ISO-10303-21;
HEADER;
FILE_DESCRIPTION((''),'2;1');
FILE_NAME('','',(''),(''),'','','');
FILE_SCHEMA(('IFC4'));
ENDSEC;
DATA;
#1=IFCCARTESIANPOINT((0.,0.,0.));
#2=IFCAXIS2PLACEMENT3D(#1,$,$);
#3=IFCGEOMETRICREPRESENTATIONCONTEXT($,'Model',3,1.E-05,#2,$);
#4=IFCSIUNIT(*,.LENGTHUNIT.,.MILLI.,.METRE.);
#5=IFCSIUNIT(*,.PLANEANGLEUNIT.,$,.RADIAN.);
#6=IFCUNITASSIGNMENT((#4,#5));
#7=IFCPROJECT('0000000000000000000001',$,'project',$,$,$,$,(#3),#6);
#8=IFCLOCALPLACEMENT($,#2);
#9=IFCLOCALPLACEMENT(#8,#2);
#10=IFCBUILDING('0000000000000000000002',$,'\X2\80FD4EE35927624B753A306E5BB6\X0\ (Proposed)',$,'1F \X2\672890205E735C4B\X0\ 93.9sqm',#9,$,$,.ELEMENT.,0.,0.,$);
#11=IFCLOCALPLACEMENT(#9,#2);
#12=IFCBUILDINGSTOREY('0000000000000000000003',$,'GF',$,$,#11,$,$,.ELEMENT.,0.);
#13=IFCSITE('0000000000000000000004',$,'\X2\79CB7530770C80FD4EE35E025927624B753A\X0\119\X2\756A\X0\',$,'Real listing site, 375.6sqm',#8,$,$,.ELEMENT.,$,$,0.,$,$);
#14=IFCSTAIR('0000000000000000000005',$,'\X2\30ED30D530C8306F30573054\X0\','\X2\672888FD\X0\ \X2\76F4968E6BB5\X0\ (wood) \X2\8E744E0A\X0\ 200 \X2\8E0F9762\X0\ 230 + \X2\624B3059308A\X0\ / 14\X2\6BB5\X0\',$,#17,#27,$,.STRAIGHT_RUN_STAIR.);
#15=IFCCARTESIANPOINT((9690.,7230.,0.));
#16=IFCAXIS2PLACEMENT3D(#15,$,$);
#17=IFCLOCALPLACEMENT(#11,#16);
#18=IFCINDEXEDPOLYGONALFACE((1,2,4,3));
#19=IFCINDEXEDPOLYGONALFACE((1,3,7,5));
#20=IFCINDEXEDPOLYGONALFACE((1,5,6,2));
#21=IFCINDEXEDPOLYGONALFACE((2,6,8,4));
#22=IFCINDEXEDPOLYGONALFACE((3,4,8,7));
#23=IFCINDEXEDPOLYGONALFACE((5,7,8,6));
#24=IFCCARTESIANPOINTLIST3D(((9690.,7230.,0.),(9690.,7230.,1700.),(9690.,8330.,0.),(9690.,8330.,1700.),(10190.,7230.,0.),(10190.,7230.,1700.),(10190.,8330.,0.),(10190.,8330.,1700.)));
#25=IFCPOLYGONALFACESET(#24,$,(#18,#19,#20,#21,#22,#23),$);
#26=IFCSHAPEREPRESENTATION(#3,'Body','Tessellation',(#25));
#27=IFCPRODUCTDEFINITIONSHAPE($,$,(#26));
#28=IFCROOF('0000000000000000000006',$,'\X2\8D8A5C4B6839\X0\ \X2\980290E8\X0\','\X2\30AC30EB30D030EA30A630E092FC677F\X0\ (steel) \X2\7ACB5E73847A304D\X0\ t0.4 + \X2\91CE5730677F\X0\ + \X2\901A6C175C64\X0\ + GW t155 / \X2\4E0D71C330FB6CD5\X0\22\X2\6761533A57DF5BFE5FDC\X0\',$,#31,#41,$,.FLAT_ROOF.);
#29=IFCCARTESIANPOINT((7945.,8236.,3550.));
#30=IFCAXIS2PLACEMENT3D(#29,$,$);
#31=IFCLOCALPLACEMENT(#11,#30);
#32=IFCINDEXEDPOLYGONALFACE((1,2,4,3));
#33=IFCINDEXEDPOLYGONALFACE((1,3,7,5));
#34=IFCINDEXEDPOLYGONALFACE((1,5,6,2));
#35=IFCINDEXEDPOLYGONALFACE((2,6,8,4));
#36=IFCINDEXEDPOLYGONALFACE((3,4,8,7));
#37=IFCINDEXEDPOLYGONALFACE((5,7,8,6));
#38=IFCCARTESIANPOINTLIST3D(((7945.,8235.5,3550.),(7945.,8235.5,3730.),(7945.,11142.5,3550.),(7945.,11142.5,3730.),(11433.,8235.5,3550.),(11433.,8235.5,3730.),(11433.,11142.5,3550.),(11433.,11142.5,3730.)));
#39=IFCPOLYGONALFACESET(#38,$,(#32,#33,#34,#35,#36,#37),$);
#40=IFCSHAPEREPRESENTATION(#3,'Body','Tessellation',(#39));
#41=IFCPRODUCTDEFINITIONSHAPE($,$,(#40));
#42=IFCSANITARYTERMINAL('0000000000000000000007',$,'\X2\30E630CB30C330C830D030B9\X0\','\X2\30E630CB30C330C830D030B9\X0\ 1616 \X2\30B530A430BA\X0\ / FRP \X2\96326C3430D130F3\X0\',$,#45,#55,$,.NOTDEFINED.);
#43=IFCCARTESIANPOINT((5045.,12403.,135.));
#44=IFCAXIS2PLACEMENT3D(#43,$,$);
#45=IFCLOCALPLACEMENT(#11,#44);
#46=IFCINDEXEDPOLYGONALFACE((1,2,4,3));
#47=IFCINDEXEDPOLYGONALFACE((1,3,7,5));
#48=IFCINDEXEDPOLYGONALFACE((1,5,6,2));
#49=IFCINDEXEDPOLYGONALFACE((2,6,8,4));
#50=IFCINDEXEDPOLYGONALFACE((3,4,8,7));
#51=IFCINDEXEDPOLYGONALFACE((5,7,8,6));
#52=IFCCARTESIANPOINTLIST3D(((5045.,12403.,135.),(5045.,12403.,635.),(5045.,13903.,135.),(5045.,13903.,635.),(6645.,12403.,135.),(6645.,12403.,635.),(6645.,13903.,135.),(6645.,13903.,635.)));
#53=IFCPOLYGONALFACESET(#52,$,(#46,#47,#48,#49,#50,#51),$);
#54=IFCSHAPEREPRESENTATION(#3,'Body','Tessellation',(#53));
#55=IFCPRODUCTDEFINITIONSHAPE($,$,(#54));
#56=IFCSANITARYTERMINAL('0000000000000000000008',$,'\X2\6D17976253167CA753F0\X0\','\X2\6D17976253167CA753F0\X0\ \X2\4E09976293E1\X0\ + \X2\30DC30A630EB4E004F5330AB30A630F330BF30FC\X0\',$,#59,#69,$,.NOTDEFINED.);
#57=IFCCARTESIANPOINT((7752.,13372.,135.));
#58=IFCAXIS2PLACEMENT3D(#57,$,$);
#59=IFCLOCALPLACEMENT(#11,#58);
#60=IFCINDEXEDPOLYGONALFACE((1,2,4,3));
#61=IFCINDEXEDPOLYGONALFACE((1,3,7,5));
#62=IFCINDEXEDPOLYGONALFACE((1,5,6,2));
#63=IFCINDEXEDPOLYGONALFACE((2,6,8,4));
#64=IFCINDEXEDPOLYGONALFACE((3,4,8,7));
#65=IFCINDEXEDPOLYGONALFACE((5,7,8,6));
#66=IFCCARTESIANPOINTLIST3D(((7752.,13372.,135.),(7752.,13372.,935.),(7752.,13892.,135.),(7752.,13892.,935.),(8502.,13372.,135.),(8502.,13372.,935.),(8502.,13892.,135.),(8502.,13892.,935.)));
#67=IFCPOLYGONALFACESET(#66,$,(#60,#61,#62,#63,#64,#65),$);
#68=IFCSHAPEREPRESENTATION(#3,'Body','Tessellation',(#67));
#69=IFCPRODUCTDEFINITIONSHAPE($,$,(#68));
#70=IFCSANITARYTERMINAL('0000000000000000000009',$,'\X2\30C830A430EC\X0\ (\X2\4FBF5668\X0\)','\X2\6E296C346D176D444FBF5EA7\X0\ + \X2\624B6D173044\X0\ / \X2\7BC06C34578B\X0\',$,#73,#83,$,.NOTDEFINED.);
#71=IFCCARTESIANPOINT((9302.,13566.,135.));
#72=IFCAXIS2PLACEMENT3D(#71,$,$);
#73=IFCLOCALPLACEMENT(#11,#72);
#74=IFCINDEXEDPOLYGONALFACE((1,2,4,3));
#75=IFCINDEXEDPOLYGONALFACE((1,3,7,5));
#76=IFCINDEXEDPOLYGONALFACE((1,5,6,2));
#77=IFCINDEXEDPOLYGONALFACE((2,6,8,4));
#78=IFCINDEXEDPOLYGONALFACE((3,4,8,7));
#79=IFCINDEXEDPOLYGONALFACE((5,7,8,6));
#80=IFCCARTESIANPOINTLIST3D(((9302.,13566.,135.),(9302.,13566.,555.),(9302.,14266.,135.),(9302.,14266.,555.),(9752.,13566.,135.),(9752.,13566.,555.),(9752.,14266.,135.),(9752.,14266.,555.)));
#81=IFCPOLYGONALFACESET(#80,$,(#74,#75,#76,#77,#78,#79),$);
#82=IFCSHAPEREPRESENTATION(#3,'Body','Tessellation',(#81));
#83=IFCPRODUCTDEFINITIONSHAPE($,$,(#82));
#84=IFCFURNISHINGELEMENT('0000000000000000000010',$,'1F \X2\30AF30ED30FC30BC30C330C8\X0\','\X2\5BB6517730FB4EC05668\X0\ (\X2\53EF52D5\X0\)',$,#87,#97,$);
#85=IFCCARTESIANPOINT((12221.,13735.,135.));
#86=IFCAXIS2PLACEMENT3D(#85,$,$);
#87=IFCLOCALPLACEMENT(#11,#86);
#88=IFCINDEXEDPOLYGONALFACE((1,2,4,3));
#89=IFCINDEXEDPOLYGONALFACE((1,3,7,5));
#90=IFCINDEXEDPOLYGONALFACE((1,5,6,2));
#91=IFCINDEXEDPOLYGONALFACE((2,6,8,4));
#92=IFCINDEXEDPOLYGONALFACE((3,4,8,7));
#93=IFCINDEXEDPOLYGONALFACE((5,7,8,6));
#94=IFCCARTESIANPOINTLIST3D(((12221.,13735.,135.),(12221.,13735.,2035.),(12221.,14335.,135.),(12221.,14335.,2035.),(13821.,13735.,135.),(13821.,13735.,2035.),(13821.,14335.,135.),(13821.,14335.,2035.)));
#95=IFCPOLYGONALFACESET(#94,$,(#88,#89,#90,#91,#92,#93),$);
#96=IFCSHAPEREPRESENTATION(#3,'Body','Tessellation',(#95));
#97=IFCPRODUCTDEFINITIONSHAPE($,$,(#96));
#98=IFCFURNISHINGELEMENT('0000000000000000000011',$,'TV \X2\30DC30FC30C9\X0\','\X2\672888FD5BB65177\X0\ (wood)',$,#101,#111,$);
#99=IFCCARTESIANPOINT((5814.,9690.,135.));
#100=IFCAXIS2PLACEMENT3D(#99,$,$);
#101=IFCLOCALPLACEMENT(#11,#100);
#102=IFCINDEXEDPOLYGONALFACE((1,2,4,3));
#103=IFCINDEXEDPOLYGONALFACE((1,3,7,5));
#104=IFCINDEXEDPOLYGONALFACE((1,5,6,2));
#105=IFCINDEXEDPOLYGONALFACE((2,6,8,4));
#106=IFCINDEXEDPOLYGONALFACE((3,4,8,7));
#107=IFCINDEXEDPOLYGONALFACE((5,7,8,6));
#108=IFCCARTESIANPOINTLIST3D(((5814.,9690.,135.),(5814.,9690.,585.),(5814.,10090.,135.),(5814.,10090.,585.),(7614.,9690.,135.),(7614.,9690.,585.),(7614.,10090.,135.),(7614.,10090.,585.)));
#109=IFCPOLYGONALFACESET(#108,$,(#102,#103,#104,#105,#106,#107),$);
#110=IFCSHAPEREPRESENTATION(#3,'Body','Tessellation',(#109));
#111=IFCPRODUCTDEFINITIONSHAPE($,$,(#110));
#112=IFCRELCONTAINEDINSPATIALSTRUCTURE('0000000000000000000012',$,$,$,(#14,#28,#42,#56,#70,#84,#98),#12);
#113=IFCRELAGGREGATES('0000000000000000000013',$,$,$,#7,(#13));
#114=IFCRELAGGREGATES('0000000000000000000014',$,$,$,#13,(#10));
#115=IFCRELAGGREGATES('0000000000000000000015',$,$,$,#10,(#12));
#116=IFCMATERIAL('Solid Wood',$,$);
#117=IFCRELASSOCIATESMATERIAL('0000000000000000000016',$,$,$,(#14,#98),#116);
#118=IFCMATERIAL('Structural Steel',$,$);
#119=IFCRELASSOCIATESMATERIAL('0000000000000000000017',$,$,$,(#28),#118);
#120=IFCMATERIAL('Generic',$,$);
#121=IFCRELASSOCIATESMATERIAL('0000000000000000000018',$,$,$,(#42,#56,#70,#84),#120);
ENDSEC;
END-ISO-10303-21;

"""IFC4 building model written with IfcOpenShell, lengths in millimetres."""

from ifc_helpers import new_model, si_unit, frame, frame_2d, origin, place, context, project, spatial, rectangle, extrude, material, element, save


model = new_model("IFC4")

# Units and contexts
model_context = context("Model", 3, precision=1e-05, world=origin())
ifc_project = project(units=[si_unit("LENGTHUNIT", "METRE", prefix="MILLI"), si_unit("PLANEANGLEUNIT", "RADIAN")], contexts=[model_context])

# Site, building, storey
site_placement = place(None, origin())
site = spatial("IfcSite", under=ifc_project, at=site_placement, Name="秋田県能代市大手町119番", ObjectType="Real listing site, 375.6sqm", CompositionType="ELEMENT", RefElevation=0.0)
building_placement = place(site_placement, origin())
building = spatial("IfcBuilding", under=site, at=building_placement, Name="能代大手町の家 (Proposed)", ObjectType="1F 木造平屋 93.9sqm", CompositionType="ELEMENT", ElevationOfRefHeight=0.0, ElevationOfTerrain=0.0)
storey_placement = place(building_placement, origin())
storey = spatial("IfcBuildingStorey", under=building, at=storey_placement, Name="GF", CompositionType="ELEMENT", Elevation=0.0)

# Shared definitions
ifc_material_1 = material(Name="Solid Wood")

# Stair
stair_placement = place(storey_placement, frame((9690.0, 7230.0, 0.0)))
element("IfcStair", 1, at=stair_placement, inside=storey, material=ifc_material_1, Name="ロフトはしご", Description="木製 直階段 (wood) 蹴上 200 踏面 230 + 手すり / 14段", PredefinedType="STRAIGHT_RUN_STAIR", context=model_context, shape_type="SweptSolid", body=[
    extrude(rectangle(XDim=500.0, YDim=1100.0, at=frame_2d((250.0, 550.0))), frame((9690.0, 7230.0, 0.0)), (0.0, 0.0, 1.0), 1700.0),
])

# Roof
ifc_material_2 = material(Name="Structural Steel")
roof_placement = place(storey_placement, frame((7945.0, 8236.0, 3550.0)))
element("IfcRoof", 2, at=roof_placement, inside=storey, material=ifc_material_2, Name="越屋根 頂部", Description="ガルバリウム鋼板 (steel) 立平葺き t0.4 + 野地板 + 通気層 + GW t155 / 不燃・法22条区域対応", PredefinedType="FLAT_ROOF", context=model_context, shape_type="SweptSolid", body=[
    extrude(rectangle(XDim=3488.0, YDim=2907.0, at=frame_2d((1744.0, 1453.0))), frame((7945.0, 8236.0, 3550.0)), (0.0, 0.0, 1.0), 180.0),
])

# Sanitary terminals
ifc_material_3 = material(Name="Generic")
sanitary_terminal_1_placement = place(storey_placement, frame((5045.0, 12403.0, 135.0)))
element("IfcSanitaryTerminal", 3, at=sanitary_terminal_1_placement, inside=storey, material=ifc_material_3, Name="ユニットバス", Description="ユニットバス 1616 サイズ / FRP 防水パン", PredefinedType="NOTDEFINED", context=model_context, shape_type="SweptSolid", body=[
    extrude(rectangle(XDim=1600.0, YDim=1500.0, at=frame_2d((800.0, 750.0))), frame((5045.0, 12403.0, 135.0)), (0.0, 0.0, 1.0), 500.0),
])
sanitary_terminal_2_placement = place(storey_placement, frame((7752.0, 13372.0, 135.0)))
element("IfcSanitaryTerminal", 4, at=sanitary_terminal_2_placement, inside=storey, material=ifc_material_3, Name="洗面化粧台", Description="洗面化粧台 三面鏡 + ボウル一体カウンター", PredefinedType="NOTDEFINED", context=model_context, shape_type="SweptSolid", body=[
    extrude(rectangle(XDim=750.0, YDim=520.0, at=frame_2d((375.0, 260.0))), frame((7752.0, 13372.0, 135.0)), (0.0, 0.0, 1.0), 800.0),
])
sanitary_terminal_3_placement = place(storey_placement, frame((9302.0, 13566.0, 135.0)))
element("IfcSanitaryTerminal", 5, at=sanitary_terminal_3_placement, inside=storey, material=ifc_material_3, Name="トイレ (便器)", Description="温水洗浄便座 + 手洗い / 節水型", PredefinedType="NOTDEFINED", context=model_context, shape_type="SweptSolid", body=[
    extrude(rectangle(XDim=450.0, YDim=700.0, at=frame_2d((225.0, 350.0))), frame((9302.0, 13566.0, 135.0)), (0.0, 0.0, 1.0), 420.0),
])

# Furnishing elements
furnishing_1_placement = place(storey_placement, frame((12221.0, 13735.0, 135.0)))
element("IfcFurnishingElement", 6, at=furnishing_1_placement, inside=storey, material=ifc_material_3, Name="1F クローゼット", Description="家具・什器 (可動)", context=model_context, shape_type="SweptSolid", body=[
    extrude(rectangle(XDim=1600.0, YDim=600.0, at=frame_2d((800.0, 300.0))), frame((12221.0, 13735.0, 135.0)), (0.0, 0.0, 1.0), 1900.0),
])
furnishing_2_placement = place(storey_placement, frame((5814.0, 9690.0, 135.0)))
element("IfcFurnishingElement", 7, at=furnishing_2_placement, inside=storey, material=ifc_material_1, Name="TV ボード", Description="木製家具 (wood)", context=model_context, shape_type="SweptSolid", body=[
    extrude(rectangle(XDim=1800.0, YDim=400.0, at=frame_2d((900.0, 200.0))), frame((5814.0, 9690.0, 135.0)), (0.0, 0.0, 1.0), 450.0),
])

save(model, "model.ifc")
